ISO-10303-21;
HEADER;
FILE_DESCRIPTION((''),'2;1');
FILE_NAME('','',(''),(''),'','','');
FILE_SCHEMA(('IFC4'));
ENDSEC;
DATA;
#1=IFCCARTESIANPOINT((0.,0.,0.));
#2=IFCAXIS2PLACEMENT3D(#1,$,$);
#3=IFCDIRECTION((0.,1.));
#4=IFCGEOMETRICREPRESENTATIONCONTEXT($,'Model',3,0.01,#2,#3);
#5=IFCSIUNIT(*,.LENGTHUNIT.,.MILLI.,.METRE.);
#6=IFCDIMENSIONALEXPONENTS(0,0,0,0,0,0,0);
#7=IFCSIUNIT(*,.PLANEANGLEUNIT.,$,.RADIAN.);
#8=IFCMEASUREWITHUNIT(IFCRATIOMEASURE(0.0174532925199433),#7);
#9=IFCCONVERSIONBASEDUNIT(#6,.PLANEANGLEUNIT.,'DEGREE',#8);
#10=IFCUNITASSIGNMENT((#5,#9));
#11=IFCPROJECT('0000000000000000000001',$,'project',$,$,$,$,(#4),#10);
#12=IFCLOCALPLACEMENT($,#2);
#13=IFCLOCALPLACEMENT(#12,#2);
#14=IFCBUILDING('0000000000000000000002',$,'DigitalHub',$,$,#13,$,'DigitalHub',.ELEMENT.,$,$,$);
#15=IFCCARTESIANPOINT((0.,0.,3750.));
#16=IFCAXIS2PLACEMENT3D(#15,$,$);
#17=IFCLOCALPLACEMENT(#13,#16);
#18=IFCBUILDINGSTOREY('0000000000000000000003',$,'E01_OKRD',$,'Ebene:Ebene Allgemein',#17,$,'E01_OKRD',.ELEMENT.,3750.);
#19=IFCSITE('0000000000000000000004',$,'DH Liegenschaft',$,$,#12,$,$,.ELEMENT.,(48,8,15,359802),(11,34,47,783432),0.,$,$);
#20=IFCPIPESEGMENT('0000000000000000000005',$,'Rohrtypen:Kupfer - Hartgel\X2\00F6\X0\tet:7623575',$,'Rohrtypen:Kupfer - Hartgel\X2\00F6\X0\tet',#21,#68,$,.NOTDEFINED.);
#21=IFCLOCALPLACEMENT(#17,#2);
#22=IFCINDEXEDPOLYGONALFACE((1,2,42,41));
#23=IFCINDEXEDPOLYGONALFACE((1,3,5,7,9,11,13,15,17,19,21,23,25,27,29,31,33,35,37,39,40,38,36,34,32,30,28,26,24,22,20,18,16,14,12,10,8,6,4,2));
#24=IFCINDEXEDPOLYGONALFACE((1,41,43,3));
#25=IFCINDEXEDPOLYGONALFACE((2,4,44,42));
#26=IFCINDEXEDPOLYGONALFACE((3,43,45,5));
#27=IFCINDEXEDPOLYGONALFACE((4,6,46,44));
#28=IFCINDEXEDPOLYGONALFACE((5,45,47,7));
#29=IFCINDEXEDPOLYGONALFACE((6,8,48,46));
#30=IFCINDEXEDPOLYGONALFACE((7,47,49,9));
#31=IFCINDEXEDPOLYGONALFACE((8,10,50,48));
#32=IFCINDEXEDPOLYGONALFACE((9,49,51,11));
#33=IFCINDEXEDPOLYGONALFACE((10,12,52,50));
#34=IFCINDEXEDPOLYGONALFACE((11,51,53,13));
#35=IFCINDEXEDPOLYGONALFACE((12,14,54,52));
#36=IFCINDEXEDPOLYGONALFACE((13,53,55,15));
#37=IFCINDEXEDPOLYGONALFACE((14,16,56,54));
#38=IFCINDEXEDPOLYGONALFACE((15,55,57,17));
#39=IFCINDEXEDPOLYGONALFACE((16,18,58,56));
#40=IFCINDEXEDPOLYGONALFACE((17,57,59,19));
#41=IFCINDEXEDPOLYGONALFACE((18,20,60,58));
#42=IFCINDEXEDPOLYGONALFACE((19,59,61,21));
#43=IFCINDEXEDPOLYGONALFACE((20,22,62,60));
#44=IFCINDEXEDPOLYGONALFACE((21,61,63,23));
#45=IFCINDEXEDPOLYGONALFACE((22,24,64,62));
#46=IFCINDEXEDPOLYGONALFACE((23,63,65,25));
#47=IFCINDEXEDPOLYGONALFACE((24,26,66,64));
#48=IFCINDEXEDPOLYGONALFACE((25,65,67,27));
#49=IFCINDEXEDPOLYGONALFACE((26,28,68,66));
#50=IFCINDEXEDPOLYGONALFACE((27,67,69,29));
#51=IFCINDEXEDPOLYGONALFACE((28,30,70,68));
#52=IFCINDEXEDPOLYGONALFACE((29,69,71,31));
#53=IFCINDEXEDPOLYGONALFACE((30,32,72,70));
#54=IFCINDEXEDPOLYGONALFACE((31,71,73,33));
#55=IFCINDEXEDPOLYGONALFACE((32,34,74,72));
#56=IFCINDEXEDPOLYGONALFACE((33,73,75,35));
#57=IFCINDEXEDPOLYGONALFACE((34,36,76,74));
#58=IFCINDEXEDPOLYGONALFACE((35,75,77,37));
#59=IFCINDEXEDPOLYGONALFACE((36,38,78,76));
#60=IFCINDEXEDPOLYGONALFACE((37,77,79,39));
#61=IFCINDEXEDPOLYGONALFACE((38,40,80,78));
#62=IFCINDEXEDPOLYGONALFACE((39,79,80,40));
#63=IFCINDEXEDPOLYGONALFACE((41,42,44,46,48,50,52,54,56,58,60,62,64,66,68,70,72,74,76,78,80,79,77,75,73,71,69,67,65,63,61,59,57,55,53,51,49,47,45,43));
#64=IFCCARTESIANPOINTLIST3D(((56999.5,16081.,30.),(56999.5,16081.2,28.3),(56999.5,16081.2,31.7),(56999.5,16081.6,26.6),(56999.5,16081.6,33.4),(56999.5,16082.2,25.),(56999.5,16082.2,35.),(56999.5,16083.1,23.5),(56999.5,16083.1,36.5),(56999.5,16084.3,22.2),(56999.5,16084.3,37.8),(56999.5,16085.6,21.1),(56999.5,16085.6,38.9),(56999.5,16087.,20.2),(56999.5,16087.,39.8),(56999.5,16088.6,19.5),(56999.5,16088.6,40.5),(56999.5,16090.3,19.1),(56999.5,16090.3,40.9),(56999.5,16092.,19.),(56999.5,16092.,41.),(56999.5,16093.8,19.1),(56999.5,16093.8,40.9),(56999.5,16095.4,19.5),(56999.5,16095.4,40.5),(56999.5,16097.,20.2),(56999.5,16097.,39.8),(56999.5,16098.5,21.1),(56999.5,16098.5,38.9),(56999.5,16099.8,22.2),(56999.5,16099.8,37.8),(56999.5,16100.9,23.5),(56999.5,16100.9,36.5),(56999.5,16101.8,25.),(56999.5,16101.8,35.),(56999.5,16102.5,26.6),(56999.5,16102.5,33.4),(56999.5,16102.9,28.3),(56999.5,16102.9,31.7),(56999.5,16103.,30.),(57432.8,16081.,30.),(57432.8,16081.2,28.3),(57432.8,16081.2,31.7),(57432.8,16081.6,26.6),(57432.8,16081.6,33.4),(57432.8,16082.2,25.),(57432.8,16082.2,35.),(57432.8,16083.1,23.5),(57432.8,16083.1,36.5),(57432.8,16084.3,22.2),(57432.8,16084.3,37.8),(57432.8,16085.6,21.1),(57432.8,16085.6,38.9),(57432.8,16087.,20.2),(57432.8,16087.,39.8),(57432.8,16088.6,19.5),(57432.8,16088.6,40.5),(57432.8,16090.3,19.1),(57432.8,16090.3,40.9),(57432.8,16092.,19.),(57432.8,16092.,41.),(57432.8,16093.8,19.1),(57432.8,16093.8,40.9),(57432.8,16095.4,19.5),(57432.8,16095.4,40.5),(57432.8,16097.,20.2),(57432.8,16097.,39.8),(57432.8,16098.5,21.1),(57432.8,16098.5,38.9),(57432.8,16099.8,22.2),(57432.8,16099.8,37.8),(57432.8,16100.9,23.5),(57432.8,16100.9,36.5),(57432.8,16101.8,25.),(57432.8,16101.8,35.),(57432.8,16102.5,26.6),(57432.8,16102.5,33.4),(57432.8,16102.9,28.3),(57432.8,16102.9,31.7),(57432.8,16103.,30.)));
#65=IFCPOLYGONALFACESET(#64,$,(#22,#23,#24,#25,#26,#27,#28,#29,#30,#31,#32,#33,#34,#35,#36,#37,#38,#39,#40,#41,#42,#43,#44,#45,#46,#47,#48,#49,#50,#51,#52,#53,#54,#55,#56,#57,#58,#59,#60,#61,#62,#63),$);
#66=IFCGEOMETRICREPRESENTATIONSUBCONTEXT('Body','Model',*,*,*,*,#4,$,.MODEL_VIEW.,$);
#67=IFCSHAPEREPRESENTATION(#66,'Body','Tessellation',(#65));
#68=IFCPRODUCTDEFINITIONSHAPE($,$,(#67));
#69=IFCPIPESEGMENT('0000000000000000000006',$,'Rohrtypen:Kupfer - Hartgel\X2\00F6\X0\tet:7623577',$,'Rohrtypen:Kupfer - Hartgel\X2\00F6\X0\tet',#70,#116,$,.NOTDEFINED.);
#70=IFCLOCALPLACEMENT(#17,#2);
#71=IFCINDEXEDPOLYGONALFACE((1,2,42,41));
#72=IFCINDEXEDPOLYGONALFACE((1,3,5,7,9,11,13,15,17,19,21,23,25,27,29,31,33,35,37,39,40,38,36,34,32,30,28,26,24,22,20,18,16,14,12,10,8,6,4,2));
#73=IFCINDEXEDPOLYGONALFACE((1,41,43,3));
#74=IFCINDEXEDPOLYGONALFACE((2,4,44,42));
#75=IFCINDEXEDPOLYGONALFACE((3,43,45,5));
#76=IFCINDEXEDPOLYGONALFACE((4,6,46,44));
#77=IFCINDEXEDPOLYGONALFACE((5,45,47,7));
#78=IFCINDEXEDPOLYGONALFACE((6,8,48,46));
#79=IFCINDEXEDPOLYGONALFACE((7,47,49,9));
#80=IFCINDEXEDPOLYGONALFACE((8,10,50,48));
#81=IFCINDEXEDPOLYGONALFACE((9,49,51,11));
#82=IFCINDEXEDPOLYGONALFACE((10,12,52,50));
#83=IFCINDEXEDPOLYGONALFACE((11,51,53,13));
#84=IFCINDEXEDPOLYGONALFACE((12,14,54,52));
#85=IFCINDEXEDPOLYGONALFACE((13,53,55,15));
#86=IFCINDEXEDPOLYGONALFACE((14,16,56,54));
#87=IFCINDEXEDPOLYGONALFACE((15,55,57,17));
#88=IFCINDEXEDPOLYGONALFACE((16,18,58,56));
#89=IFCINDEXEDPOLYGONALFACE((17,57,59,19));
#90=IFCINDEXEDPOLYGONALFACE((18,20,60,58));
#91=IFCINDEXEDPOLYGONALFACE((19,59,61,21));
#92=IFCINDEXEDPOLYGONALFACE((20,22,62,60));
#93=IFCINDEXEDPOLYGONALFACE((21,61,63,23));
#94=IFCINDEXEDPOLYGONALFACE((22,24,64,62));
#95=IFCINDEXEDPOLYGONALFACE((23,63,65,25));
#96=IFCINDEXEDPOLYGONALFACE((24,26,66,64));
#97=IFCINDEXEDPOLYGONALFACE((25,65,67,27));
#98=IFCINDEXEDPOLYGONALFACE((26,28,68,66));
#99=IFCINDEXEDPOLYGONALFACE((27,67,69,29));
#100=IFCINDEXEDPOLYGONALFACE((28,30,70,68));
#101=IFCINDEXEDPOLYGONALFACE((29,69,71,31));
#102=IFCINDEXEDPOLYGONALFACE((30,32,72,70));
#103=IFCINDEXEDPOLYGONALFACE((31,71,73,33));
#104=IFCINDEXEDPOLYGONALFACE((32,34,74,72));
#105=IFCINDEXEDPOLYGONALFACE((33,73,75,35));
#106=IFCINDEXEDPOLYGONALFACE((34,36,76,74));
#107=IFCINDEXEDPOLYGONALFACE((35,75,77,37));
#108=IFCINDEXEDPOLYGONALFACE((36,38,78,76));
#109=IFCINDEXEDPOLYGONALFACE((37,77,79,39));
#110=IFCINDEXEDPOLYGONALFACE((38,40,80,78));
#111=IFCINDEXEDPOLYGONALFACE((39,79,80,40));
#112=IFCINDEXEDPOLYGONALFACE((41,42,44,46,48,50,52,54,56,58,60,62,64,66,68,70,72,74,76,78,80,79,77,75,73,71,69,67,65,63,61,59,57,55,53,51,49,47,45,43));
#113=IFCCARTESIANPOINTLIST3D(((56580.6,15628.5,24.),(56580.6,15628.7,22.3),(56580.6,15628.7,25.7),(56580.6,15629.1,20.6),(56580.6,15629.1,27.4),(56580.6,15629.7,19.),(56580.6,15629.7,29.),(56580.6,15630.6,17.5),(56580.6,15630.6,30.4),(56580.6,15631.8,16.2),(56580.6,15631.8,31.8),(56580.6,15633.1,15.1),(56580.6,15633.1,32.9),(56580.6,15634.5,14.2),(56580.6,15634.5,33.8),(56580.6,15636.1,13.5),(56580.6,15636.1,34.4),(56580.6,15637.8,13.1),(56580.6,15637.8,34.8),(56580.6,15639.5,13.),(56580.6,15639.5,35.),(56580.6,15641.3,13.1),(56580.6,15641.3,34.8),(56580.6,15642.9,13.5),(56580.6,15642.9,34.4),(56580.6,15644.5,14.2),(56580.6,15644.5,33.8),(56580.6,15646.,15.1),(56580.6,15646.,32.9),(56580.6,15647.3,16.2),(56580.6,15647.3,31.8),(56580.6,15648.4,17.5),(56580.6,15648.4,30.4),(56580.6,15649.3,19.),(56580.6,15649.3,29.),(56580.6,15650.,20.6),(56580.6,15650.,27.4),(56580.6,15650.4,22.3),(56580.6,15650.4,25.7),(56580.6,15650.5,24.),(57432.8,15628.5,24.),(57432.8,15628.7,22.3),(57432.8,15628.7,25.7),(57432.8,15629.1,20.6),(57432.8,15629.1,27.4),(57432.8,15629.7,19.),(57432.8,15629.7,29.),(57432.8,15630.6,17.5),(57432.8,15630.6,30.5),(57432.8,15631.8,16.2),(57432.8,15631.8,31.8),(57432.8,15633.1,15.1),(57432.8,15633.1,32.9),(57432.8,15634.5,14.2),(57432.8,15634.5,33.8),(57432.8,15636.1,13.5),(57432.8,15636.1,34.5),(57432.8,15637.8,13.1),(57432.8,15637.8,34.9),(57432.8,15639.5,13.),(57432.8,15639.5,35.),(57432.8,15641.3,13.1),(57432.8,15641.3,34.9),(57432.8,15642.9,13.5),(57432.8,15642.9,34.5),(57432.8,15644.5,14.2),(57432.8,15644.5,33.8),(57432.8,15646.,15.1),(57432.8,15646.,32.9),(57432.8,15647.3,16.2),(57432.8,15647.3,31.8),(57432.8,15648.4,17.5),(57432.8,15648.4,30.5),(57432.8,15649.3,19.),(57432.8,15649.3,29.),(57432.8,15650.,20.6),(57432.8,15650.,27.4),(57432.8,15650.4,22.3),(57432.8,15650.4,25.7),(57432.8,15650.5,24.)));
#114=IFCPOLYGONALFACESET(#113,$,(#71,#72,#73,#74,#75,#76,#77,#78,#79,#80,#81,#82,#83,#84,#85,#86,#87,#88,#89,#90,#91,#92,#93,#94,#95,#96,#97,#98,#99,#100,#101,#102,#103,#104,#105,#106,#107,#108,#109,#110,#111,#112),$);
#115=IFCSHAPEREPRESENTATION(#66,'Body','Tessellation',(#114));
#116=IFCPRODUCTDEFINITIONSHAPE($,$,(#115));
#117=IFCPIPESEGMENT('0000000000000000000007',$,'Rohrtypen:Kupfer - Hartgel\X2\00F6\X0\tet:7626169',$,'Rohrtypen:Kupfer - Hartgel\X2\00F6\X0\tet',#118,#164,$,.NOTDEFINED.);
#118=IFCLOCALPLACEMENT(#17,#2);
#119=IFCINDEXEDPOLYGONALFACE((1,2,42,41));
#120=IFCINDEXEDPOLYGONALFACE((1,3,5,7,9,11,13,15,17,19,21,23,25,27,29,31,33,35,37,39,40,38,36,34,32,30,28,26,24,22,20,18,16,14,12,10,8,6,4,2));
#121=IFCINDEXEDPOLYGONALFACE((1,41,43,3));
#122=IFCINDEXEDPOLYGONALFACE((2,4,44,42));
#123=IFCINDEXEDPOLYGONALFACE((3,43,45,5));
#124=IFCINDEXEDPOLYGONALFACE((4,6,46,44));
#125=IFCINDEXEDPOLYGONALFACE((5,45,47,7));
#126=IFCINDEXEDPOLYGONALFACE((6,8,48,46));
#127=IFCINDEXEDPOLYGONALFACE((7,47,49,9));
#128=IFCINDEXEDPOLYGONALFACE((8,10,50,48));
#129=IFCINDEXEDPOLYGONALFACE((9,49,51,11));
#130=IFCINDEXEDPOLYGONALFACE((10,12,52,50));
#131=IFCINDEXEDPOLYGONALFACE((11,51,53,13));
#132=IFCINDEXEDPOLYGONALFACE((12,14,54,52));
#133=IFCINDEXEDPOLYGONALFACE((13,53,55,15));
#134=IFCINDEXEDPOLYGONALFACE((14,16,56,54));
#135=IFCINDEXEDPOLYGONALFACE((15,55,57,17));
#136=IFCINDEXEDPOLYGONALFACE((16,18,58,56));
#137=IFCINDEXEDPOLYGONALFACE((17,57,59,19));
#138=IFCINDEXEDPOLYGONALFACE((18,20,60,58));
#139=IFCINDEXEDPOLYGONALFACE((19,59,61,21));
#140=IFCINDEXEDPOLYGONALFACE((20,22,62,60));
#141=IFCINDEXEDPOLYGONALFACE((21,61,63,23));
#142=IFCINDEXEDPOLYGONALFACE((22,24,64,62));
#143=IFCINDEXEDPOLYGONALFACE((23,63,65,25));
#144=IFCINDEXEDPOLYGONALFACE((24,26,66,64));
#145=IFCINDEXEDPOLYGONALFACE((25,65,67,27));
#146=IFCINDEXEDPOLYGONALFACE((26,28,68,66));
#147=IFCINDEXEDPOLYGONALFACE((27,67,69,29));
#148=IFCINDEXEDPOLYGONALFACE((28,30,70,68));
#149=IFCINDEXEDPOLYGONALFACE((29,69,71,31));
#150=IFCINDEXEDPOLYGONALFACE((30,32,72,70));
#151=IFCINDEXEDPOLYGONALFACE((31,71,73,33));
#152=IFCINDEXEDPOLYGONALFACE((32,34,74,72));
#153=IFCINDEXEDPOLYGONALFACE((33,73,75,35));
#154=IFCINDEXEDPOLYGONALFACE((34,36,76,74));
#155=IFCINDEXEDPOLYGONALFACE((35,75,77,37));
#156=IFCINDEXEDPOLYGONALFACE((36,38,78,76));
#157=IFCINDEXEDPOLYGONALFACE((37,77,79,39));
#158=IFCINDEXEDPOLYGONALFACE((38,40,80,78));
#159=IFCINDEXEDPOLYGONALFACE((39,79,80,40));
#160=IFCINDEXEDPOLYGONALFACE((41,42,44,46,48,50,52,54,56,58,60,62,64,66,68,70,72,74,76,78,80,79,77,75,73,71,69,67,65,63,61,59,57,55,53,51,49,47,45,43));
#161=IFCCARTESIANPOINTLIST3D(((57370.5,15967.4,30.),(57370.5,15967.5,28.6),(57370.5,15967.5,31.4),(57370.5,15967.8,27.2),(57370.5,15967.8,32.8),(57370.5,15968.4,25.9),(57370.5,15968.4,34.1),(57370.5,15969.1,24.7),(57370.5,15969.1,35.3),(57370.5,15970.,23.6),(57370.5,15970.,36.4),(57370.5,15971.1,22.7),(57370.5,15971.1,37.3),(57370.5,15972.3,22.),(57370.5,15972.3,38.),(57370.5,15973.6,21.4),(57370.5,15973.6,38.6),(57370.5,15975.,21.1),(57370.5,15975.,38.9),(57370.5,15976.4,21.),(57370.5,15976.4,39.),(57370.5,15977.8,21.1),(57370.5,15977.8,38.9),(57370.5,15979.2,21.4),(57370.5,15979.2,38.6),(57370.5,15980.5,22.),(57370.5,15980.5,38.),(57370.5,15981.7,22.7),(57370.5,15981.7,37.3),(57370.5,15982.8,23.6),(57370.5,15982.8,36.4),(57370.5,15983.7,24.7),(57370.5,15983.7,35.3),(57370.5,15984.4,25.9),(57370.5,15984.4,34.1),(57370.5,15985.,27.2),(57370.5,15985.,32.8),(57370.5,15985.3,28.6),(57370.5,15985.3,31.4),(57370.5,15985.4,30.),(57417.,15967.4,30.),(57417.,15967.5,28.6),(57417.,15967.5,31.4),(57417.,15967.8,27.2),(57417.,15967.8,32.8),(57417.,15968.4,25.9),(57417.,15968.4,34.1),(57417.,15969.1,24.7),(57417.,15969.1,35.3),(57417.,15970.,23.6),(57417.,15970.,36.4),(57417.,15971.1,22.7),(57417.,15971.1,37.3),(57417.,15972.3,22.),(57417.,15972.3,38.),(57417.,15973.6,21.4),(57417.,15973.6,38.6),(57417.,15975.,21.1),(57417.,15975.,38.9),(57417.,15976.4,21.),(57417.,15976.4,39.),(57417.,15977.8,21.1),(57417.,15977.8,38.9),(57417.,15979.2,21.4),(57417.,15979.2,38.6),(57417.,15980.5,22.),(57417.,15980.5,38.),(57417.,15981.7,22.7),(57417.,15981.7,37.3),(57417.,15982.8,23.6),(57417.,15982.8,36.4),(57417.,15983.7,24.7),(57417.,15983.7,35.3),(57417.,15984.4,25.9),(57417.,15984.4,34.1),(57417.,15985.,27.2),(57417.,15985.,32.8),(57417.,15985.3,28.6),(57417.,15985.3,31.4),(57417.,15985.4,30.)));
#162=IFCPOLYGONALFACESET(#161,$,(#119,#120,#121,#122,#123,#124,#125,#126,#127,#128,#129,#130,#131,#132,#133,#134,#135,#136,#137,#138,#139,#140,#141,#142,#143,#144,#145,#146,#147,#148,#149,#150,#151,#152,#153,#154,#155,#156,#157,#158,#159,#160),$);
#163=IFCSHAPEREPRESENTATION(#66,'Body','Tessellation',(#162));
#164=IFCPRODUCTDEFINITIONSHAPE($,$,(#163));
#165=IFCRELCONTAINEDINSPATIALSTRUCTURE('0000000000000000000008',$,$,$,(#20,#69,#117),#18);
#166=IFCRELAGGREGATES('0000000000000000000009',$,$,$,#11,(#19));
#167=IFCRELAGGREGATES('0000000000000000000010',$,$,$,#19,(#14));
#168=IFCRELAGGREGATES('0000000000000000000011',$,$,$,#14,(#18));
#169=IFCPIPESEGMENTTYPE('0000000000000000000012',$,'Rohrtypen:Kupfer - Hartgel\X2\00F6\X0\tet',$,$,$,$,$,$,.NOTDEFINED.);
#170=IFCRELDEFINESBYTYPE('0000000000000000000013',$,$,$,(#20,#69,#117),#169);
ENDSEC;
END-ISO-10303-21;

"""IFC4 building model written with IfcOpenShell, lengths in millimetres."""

from ifc_helpers import new_model, entity, si_unit, converted_unit, direction, frame, origin, place, context, subcontext, project, spatial, indexed_curve, outline, extrude, type_object, element, save


model = new_model("IFC4")

# Units and contexts
model_context = context("Model", 3, precision=0.01, world=origin(), true_north=direction((0.0, 1.0)))
body_context = subcontext(model_context, "Body", "Model", "MODEL_VIEW")
ifc_project = project(units=[si_unit("LENGTHUNIT", "METRE", prefix="MILLI"), converted_unit("PLANEANGLEUNIT", "DEGREE", entity("IfcRatioMeasure", 0.0174532925199433), si_unit("PLANEANGLEUNIT", "RADIAN"), dimensions=[0, 0, 0, 0, 0, 0, 0])], contexts=[model_context])

# Site, building, storey
site_placement = place(None, origin())
site = spatial("IfcSite", under=ifc_project, at=site_placement, Name="DH Liegenschaft", CompositionType="ELEMENT", RefLatitude=(48, 8, 15, 359802), RefLongitude=(11, 34, 47, 783432), RefElevation=0.0)
building_placement = place(site_placement, origin())
building = spatial("IfcBuilding", under=site, at=building_placement, Name="DigitalHub", LongName="DigitalHub", CompositionType="ELEMENT")
storey_placement = place(building_placement, frame((0.0, 0.0, 3750.0)))
storey = spatial("IfcBuildingStorey", under=building, at=storey_placement, Name="E01_OKRD", ObjectType="Ebene:Ebene Allgemein", LongName="E01_OKRD", CompositionType="ELEMENT", Elevation=3750.0)

# Pipe segments
pipe_segment_type = type_object("IfcPipeSegmentType", Name="Rohrtypen:Kupfer - Hartgelötet", PredefinedType="NOTDEFINED")
pipe_segment_1_placement = place(storey_placement, frame((56999.5, 16079.4, 17.4)))
element("IfcPipeSegment", 1, at=pipe_segment_1_placement, inside=storey, type_object=pipe_segment_type, Name="Rohrtypen:Kupfer - Hartgelötet:7623575", ObjectType="Rohrtypen:Kupfer - Hartgelötet", PredefinedType="NOTDEFINED", context=body_context, shape_type="SweptSolid", body=[
    extrude(outline(indexed_curve([(11.0, 0.0), (10.9, 1.7), (10.5, 3.4), (9.8, 5.0), (8.9, 6.5), (7.8, 7.8), (6.5, 8.9), (5.0, 9.8), (3.4, 10.5), (1.7, 10.9), (0.0, 11.0), (-1.7, 10.9), (-3.4, 10.5), (-5.0, 9.8), (-6.5, 8.9), (-7.8, 7.8), (-8.9, 6.5), (-9.8, 5.0), (-10.5, 3.4), (-10.9, 1.7), (-11.0, 0.0), (-10.9, -1.7), (-10.5, -3.4), (-9.8, -5.0), (-8.9, -6.5), (-7.8, -7.8), (-6.5, -8.9), (-5.0, -9.8), (-3.4, -10.5), (-1.7, -10.9), (0.0, -11.0), (1.7, -10.9), (3.4, -10.5), (5.0, -9.8), (6.5, -8.9), (7.8, -7.8), (8.9, -6.5), (9.8, -5.0), (10.5, -3.4), (10.9, -1.7), (11.0, 0.0)], self_intersect=False)), frame((0.0, 12.6, 12.6), z_axis=(1.0, 0.0, 0.0), x_axis=(0.0, 1.0, 0.0)), (0.0, 0.0, 1.0), 433.4),
])
pipe_segment_2_placement = place(storey_placement, frame((56580.6, 15626.9, 11.4)))
element("IfcPipeSegment", 2, at=pipe_segment_2_placement, inside=storey, type_object=pipe_segment_type, Name="Rohrtypen:Kupfer - Hartgelötet:7623577", ObjectType="Rohrtypen:Kupfer - Hartgelötet", PredefinedType="NOTDEFINED", context=body_context, shape_type="SweptSolid", body=[
    extrude(outline(indexed_curve([(11.0, 0.0), (10.9, 1.7), (10.5, 3.4), (9.8, 5.0), (8.9, 6.5), (7.8, 7.8), (6.5, 8.9), (5.0, 9.8), (3.4, 10.5), (1.7, 10.9), (0.0, 11.0), (-1.7, 10.9), (-3.4, 10.5), (-5.0, 9.8), (-6.5, 8.9), (-7.8, 7.8), (-8.9, 6.5), (-9.8, 5.0), (-10.5, 3.4), (-10.9, 1.7), (-11.0, 0.0), (-10.9, -1.7), (-10.5, -3.4), (-9.8, -5.0), (-8.9, -6.5), (-7.8, -7.8), (-6.5, -8.9), (-5.0, -9.8), (-3.4, -10.5), (-1.7, -10.9), (0.0, -11.0), (1.7, -10.9), (3.4, -10.5), (5.0, -9.8), (6.5, -8.9), (7.8, -7.8), (8.9, -6.5), (9.8, -5.0), (10.5, -3.4), (10.9, -1.7), (11.0, 0.0)], self_intersect=False)), frame((0.0, 12.6, 12.6), z_axis=(1.0, 0.0, 0.000012), x_axis=(0.0, 1.0, 0.0)), (0.0, 0.0, 1.0), 852.2),
])
pipe_segment_3_placement = place(storey_placement, frame((57370.5, 15965.8, 19.4)))
element("IfcPipeSegment", 3, at=pipe_segment_3_placement, inside=storey, type_object=pipe_segment_type, Name="Rohrtypen:Kupfer - Hartgelötet:7626169", ObjectType="Rohrtypen:Kupfer - Hartgelötet", PredefinedType="NOTDEFINED", context=body_context, shape_type="SweptSolid", body=[
    extrude(outline(indexed_curve([(9.0, 0.0), (8.9, 1.4), (8.6, 2.8), (8.0, 4.1), (7.3, 5.3), (6.4, 6.4), (5.3, 7.3), (4.1, 8.0), (2.8, 8.6), (1.4, 8.9), (0.0, 9.0), (-1.4, 8.9), (-2.8, 8.6), (-4.1, 8.0), (-5.3, 7.3), (-6.4, 6.4), (-7.3, 5.3), (-8.0, 4.1), (-8.6, 2.8), (-8.9, 1.4), (-9.0, 0.0), (-8.9, -1.4), (-8.6, -2.8), (-8.0, -4.1), (-7.3, -5.3), (-6.4, -6.4), (-5.3, -7.3), (-4.1, -8.0), (-2.8, -8.6), (-1.4, -8.9), (0.0, -9.0), (1.4, -8.9), (2.8, -8.6), (4.1, -8.0), (5.3, -7.3), (6.4, -6.4), (7.3, -5.3), (8.0, -4.1), (8.6, -2.8), (8.9, -1.4), (9.0, 0.0)], self_intersect=False)), frame((0.0, 10.6, 10.6), z_axis=(1.0, 0.0, 0.0), x_axis=(0.0, 1.0, 0.0)), (0.0, 0.0, 1.0), 46.4),
])

save(model, "model.ifc")
